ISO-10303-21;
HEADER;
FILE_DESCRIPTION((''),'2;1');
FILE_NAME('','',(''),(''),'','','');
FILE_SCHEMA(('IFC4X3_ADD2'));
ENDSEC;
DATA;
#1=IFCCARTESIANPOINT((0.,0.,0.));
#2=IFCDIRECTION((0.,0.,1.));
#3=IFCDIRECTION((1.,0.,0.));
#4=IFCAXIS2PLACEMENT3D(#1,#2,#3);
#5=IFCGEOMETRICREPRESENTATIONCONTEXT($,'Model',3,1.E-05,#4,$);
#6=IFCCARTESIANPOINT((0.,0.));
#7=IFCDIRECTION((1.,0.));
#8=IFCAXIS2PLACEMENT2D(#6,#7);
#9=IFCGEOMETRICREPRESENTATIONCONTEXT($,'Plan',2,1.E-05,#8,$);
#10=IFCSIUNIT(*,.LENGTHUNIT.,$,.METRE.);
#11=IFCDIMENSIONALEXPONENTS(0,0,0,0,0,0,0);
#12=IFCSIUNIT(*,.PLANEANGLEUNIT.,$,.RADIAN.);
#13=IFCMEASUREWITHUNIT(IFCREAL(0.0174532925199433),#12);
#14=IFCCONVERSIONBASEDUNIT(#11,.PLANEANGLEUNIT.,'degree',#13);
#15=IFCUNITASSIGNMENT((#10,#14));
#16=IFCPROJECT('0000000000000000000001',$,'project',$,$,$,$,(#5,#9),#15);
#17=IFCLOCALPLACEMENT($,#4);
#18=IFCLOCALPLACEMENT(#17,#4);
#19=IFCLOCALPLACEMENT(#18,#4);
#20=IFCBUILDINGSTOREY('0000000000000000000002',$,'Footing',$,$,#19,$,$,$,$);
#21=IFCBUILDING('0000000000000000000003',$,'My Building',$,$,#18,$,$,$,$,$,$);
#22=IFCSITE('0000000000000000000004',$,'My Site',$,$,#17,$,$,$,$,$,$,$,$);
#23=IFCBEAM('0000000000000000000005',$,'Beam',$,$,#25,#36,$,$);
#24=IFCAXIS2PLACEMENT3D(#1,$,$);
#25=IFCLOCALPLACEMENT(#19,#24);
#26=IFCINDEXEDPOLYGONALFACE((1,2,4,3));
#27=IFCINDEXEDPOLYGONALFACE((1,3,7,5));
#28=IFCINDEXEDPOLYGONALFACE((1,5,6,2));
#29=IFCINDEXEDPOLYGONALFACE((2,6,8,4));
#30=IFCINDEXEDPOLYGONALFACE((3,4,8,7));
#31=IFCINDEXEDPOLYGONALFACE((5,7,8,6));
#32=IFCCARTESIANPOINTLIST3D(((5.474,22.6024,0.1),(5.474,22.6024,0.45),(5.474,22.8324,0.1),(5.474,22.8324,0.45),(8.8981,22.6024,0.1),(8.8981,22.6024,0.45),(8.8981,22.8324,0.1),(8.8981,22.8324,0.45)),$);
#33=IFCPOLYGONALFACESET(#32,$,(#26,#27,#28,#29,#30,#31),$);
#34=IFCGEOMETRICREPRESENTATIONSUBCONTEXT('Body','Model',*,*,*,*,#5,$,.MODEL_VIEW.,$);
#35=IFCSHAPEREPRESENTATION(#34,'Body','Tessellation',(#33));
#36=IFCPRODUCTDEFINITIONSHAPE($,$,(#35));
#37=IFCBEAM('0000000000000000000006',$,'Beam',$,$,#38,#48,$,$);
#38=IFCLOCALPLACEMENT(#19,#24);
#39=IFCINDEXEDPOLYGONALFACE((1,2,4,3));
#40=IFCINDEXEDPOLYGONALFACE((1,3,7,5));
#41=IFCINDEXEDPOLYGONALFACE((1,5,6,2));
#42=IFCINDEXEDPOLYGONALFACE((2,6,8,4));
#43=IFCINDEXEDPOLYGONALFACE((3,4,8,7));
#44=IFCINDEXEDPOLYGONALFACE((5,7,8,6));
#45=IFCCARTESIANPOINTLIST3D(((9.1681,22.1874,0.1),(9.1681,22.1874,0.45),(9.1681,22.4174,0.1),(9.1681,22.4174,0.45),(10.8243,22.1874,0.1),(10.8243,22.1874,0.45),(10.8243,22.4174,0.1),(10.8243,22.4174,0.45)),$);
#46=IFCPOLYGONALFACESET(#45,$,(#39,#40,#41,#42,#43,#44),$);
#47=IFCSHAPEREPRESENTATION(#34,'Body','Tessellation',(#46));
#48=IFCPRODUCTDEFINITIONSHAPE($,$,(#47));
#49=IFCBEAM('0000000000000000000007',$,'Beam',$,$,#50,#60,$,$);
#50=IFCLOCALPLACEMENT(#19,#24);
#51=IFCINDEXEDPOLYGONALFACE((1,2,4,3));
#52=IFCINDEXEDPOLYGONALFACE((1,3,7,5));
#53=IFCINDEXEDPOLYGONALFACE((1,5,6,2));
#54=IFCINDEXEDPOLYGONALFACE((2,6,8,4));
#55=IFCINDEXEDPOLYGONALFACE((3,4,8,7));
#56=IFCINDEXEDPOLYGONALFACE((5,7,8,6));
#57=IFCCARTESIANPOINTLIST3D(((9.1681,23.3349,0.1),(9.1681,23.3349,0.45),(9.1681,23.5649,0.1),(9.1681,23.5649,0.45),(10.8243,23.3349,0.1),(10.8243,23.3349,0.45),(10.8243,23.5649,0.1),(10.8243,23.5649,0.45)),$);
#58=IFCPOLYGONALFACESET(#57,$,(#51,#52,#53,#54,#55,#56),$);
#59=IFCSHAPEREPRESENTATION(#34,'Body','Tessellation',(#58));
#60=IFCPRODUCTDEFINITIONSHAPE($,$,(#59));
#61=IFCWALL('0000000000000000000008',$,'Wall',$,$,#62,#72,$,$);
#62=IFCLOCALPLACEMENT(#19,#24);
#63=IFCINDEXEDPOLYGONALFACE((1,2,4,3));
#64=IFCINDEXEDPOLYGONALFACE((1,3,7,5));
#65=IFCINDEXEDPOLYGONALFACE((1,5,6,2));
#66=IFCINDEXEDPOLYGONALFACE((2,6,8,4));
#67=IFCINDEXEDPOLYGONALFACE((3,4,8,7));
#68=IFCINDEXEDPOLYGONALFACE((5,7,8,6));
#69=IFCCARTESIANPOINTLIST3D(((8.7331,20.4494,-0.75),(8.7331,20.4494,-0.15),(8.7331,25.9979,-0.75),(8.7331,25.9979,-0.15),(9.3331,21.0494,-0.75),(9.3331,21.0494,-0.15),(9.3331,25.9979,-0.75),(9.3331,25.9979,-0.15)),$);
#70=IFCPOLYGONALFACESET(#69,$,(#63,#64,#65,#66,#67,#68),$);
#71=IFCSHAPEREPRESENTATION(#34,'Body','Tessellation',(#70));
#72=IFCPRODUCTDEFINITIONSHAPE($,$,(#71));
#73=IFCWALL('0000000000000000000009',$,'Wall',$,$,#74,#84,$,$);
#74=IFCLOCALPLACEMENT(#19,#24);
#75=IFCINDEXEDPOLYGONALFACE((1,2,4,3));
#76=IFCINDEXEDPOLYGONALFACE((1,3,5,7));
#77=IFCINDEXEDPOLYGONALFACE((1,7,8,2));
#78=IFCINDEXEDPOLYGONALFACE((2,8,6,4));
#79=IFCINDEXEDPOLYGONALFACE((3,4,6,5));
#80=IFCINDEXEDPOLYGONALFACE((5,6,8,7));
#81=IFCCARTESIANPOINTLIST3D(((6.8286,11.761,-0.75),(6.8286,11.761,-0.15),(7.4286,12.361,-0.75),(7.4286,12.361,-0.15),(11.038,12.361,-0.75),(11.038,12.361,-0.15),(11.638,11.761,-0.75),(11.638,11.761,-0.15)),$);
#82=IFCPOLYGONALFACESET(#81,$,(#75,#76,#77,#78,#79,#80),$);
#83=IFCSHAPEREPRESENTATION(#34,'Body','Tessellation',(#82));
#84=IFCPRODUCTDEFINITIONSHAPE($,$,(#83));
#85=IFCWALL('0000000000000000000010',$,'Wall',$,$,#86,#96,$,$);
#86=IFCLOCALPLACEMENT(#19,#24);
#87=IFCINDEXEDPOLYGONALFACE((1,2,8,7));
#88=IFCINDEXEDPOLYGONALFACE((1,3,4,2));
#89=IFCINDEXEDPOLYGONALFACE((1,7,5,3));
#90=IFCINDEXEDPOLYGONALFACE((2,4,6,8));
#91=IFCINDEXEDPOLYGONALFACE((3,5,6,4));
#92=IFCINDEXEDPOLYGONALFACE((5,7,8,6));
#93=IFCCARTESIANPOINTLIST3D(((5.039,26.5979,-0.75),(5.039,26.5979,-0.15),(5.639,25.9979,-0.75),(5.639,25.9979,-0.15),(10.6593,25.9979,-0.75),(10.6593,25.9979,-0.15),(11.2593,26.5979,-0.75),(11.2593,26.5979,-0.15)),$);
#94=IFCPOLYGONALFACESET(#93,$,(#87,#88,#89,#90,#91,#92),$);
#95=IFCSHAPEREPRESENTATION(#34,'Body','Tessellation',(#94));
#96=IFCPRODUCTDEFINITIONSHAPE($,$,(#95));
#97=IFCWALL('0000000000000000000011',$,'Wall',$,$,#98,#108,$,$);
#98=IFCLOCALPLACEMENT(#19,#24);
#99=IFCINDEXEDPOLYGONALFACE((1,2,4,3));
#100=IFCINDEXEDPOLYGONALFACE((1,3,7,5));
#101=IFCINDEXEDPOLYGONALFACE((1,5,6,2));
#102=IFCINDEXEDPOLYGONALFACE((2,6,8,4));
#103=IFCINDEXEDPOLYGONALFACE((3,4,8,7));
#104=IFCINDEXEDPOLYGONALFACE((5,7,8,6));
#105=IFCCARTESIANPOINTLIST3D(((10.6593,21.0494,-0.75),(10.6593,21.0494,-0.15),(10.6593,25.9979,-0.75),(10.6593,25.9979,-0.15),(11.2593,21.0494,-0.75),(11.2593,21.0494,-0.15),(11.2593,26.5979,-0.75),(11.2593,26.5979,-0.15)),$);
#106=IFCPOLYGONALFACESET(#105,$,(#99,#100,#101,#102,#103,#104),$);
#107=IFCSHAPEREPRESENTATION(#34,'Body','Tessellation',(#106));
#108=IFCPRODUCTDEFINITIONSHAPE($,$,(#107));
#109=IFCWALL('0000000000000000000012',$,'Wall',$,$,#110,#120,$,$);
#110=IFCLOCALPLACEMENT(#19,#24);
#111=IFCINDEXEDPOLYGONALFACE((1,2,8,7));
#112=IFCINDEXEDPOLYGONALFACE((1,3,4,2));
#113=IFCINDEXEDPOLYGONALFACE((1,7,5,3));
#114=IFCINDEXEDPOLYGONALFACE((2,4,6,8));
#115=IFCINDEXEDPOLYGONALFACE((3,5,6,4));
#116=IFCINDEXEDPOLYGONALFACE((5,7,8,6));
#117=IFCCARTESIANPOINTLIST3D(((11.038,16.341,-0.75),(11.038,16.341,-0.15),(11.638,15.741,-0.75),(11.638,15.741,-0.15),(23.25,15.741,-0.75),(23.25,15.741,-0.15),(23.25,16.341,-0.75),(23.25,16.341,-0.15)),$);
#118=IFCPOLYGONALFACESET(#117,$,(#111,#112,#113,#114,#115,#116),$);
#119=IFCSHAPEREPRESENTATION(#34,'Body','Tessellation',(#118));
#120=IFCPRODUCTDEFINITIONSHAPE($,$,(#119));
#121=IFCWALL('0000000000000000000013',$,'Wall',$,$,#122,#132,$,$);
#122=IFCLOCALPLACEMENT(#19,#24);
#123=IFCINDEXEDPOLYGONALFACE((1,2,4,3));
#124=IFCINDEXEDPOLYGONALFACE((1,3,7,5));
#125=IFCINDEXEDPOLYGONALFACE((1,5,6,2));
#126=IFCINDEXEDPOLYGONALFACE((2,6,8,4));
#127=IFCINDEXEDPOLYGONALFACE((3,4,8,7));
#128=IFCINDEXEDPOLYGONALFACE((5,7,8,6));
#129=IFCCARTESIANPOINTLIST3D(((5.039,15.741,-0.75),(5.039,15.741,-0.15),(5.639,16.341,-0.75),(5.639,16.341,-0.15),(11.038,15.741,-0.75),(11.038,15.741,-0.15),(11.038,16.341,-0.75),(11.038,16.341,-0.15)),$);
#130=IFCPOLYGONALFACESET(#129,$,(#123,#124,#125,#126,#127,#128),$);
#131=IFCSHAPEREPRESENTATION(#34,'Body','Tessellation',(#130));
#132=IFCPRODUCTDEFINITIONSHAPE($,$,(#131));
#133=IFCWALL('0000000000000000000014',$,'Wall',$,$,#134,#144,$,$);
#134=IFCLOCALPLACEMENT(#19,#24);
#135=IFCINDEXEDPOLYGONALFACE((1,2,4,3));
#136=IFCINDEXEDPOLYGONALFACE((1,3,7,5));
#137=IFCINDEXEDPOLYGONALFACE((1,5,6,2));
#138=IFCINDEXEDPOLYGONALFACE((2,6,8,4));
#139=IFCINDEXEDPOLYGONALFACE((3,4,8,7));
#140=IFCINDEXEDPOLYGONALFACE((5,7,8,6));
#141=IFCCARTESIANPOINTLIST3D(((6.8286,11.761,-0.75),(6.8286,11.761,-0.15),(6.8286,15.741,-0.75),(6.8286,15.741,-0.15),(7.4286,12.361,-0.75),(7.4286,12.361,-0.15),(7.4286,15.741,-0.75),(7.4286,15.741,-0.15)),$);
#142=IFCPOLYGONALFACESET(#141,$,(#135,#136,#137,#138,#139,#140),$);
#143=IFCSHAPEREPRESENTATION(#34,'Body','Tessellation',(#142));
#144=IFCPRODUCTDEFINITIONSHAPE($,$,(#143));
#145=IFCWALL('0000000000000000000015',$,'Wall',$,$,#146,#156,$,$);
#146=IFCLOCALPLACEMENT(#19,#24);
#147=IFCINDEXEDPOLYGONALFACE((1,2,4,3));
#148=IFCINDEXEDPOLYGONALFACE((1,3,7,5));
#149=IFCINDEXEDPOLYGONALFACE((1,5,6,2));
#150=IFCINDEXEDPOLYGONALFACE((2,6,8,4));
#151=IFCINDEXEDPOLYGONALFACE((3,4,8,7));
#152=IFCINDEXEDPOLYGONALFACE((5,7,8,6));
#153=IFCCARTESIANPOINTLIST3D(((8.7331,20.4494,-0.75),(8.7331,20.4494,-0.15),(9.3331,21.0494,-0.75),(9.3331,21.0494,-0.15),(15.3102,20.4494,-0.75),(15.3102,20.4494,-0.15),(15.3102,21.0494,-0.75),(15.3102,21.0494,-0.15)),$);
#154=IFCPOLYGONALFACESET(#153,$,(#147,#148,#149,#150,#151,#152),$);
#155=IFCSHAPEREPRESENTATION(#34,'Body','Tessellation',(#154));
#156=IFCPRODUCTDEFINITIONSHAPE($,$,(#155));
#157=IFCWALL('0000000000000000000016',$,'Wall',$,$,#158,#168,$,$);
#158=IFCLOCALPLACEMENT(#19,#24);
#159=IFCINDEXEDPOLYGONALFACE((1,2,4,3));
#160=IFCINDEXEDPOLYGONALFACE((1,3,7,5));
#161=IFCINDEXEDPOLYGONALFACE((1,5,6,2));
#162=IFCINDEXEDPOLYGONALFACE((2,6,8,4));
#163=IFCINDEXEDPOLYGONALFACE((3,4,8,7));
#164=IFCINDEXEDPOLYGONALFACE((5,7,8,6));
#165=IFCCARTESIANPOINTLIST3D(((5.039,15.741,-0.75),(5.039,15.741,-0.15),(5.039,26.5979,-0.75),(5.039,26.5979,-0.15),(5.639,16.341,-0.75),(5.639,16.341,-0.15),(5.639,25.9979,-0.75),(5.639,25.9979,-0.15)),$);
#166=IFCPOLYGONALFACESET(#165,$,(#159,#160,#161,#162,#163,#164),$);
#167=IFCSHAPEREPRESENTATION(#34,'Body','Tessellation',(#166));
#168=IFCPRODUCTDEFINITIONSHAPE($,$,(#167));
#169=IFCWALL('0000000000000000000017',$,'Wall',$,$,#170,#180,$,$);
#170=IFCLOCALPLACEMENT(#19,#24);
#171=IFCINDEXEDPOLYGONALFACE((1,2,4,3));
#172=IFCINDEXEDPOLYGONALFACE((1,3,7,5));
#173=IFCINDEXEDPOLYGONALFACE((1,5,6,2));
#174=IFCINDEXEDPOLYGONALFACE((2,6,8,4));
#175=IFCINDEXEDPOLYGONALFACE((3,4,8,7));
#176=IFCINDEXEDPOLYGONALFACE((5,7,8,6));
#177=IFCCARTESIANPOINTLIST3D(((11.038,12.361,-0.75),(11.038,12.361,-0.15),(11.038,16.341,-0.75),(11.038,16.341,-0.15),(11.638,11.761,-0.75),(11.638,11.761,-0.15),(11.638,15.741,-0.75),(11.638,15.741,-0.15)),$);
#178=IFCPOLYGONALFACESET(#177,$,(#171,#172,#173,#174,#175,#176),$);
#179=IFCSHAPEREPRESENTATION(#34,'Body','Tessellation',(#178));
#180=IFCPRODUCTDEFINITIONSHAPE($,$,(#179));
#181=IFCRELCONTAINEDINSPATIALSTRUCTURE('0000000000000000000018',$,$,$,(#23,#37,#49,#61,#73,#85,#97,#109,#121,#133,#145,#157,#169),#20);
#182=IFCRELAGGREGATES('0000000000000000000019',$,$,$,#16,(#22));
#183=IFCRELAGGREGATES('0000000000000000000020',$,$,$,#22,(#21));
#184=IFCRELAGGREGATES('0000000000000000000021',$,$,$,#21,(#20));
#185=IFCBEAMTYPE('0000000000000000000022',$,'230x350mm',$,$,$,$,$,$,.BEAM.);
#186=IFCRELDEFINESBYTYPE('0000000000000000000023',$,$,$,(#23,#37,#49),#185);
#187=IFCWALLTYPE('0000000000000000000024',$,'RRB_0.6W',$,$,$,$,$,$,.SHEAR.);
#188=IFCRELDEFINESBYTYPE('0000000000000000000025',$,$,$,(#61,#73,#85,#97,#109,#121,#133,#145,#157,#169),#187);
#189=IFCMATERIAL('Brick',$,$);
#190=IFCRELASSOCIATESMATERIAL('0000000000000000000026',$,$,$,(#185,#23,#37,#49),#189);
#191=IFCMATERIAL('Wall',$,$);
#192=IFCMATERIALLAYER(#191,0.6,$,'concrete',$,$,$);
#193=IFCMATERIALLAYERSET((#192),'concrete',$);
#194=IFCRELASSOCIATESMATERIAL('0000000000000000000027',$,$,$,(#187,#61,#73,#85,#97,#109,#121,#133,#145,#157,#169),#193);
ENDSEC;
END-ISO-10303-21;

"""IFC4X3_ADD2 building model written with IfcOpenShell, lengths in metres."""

from ifc_helpers import new_model, entity, si_unit, converted_unit, frame, origin_with_axes, origin_2d_with_axis, place, context, subcontext, project, spatial, line, indexed_curve, rectangle, outline, extrude, material, layer, layer_set, layer_usage, material_profile, profile_set, profile_usage, type_object, element, save


model = new_model("IFC4X3_ADD2")

# Units and contexts
model_context = context("Model", 3, precision=1e-05, world=origin_with_axes())
plan_context = context("Plan", 2, precision=1e-05, world=origin_2d_with_axis())
body_context = subcontext(model_context, "Body", "Model", "MODEL_VIEW")
ifc_project = project(units=[si_unit("LENGTHUNIT", "METRE"), converted_unit("PLANEANGLEUNIT", "degree", entity("IfcReal", 0.0174532925199433), si_unit("PLANEANGLEUNIT", "RADIAN"), dimensions=[0, 0, 0, 0, 0, 0, 0])], contexts=[model_context, plan_context])

# Site, building, storey
site_placement = place(None, origin_with_axes())
site = spatial("IfcSite", under=ifc_project, at=site_placement, Name="My Site")
building_placement = place(site_placement, origin_with_axes())
building = spatial("IfcBuilding", under=site, at=building_placement, Name="My Building")
storey_placement = place(building_placement, origin_with_axes())
storey = spatial("IfcBuildingStorey", under=building, at=storey_placement, Name="Footing")

# Beams
ifc_material_1 = material(Name="Brick")
ifc_material_profile = material_profile(ifc_material_1, rectangle(XDim=0.23, YDim=0.35))
ifc_profile_set = profile_set([ifc_material_profile], Name="stone")
ifc_profile_usage_1 = profile_usage(ifc_profile_set)
beam_type = type_object("IfcBeamType", Name="230x350mm", PredefinedType="BEAM", material=ifc_profile_set)
beam_1_placement = place(storey_placement, frame((8.8981, 22.7174, 0.275), z_axis=(-1.0, 0.0, 0.0), x_axis=(0.0, -1.0, 0.0)))
element("IfcBeam", 1, at=beam_1_placement, inside=storey, type_object=beam_type, material=ifc_profile_usage_1, Name="Beam", context=body_context, shape_type="SweptSolid", body=[
    extrude(rectangle(XDim=0.23, YDim=0.35), origin_with_axes(), (0.0, 0.0, 1.0), 3.4241),
])
ifc_profile_usage_2 = profile_usage(ifc_profile_set)
beam_2_placement = place(storey_placement, frame((10.8243, 22.3024, 0.275), z_axis=(-1.0, 0.0, 0.0), x_axis=(0.0, -1.0, 0.0)))
element("IfcBeam", 2, at=beam_2_placement, inside=storey, type_object=beam_type, material=ifc_profile_usage_2, Name="Beam", context=body_context, shape_type="SweptSolid", body=[
    extrude(rectangle(XDim=0.23, YDim=0.35), origin_with_axes(), (0.0, 0.0, 1.0), 1.6562),
])
ifc_profile_usage_3 = profile_usage(ifc_profile_set)
beam_3_placement = place(storey_placement, frame((10.8243, 23.4499, 0.275), z_axis=(-1.0, 0.0, 0.0), x_axis=(0.0, -1.0, 0.0)))
element("IfcBeam", 3, at=beam_3_placement, inside=storey, type_object=beam_type, material=ifc_profile_usage_3, Name="Beam", context=body_context, shape_type="SweptSolid", body=[
    extrude(rectangle(XDim=0.23, YDim=0.35), origin_with_axes(), (0.0, 0.0, 1.0), 1.6562),
])

# Walls
ifc_material_2 = material(Name="Wall")
ifc_layer_1 = layer(ifc_material_2, 0.6, Name="concrete")
ifc_layer_set_1 = layer_set([ifc_layer_1], Name="concrete")
ifc_layer_usage_1 = layer_usage(ifc_layer_set_1, "AXIS2", "POSITIVE", 0.0)
wall_type_1 = type_object("IfcWallType", Name="RRB_0.6W", PredefinedType="SHEAR", material=ifc_layer_set_1)
wall_1_placement = place(storey_placement, frame((9.3331, 20.4494, -0.75), z_axis=(0.0, 0.0, 1.0), x_axis=(0.0, 1.0, 0.0)))
element("IfcWall", 4, at=wall_1_placement, inside=storey, type_object=wall_type_1, material=ifc_layer_usage_1, Name="Wall", context=body_context, shape_type="SweptSolid", body=[
    extrude(outline(indexed_curve([(0.6, 0.0), (0.0, 0.6), (5.5485, 0.6), (5.5485, 0.0)], segments=[line(1, 2, 3, 4, 1)])), origin_with_axes(), (0.0, 0.0, 1.0), 0.6),
])
ifc_layer_usage_2 = layer_usage(ifc_layer_set_1, "AXIS2", "POSITIVE", 0.0)
wall_2_placement = place(storey_placement, frame((11.638, 12.361, -0.75), z_axis=(0.0, 0.0, 1.0), x_axis=(-1.0, 0.0, 0.0)))
element("IfcWall", 5, at=wall_2_placement, inside=storey, type_object=wall_type_1, material=ifc_layer_usage_2, Name="Wall", context=body_context, shape_type="SweptSolid", body=[
    extrude(outline(indexed_curve([(0.6, 0.0), (0.0, 0.6), (4.8094, 0.6), (4.2094, 0.0)], segments=[line(1, 2, 3, 4, 1)])), origin_with_axes(), (0.0, 0.0, 1.0), 0.6),
])
ifc_layer_usage_3 = layer_usage(ifc_layer_set_1, "AXIS2", "POSITIVE", 0.0)
wall_3_placement = place(storey_placement, frame((11.2593, 26.5979, -0.75), z_axis=(0.0, 0.0, 1.0), x_axis=(-1.0, 0.0, 0.0)))
element("IfcWall", 6, at=wall_3_placement, inside=storey, type_object=wall_type_1, material=ifc_layer_usage_3, Name="Wall", context=body_context, shape_type="SweptSolid", body=[
    extrude(outline(indexed_curve([(0.0, 0.0), (0.6, 0.6), (5.6203, 0.6), (6.2203, 0.0)], segments=[line(1, 2, 3, 4, 1)])), origin_with_axes(), (0.0, 0.0, 1.0), 0.6),
])
ifc_layer_usage_4 = layer_usage(ifc_layer_set_1, "AXIS2", "POSITIVE", 0.0)
wall_4_placement = place(storey_placement, frame((11.2593, 20.4494, -0.75), z_axis=(0.0, 0.0, 1.0), x_axis=(0.0, 1.0, 0.0)))
element("IfcWall", 7, at=wall_4_placement, inside=storey, type_object=wall_type_1, material=ifc_layer_usage_4, Name="Wall", context=body_context, shape_type="SweptSolid", body=[
    extrude(outline(indexed_curve([(0.6, 0.0), (0.6, 0.6), (5.5485, 0.6), (6.1485, 0.0)], segments=[line(1, 2, 3, 4, 1)])), origin_with_axes(), (0.0, 0.0, 1.0), 0.6),
])
ifc_layer_usage_5 = layer_usage(ifc_layer_set_1, "AXIS2", "POSITIVE", 0.0)
wall_5_placement = place(storey_placement, frame((11.638, 15.741, -0.75), z_axis=(0.0, 0.0, 1.0), x_axis=(1.0, -0.000001, 0.0)))
element("IfcWall", 8, at=wall_5_placement, inside=storey, type_object=wall_type_1, material=ifc_layer_usage_5, Name="Wall", context=body_context, shape_type="SweptSolid", body=[
    extrude(outline(indexed_curve([(0.0, 0.0), (-0.6, 0.6), (11.612, 0.6), (11.612, 0.0)], segments=[line(1, 2, 3, 4, 1)])), origin_with_axes(), (0.0, 0.0, 1.0), 0.6),
])
ifc_layer_usage_6 = layer_usage(ifc_layer_set_1, "AXIS2", "POSITIVE", 0.0)
wall_6_placement = place(storey_placement, frame((11.638, 16.341, -0.75), z_axis=(0.0, 0.0, 1.0), x_axis=(-1.0, 0.0, 0.0)))
element("IfcWall", 9, at=wall_6_placement, inside=storey, type_object=wall_type_1, material=ifc_layer_usage_6, Name="Wall", context=body_context, shape_type="SweptSolid", body=[
    extrude(outline(indexed_curve([(0.6, 0.0), (0.6, 0.6), (6.599, 0.6), (5.999, 0.0)], segments=[line(1, 2, 3, 4, 1)])), origin_with_axes(), (0.0, 0.0, 1.0), 0.6),
])
ifc_layer_usage_7 = layer_usage(ifc_layer_set_1, "AXIS2", "POSITIVE", 0.0)
wall_7_placement = place(storey_placement, frame((7.4286, 12.361, -0.75), z_axis=(0.0, 0.0, 1.0), x_axis=(0.0, 1.0, 0.0)))
element("IfcWall", 10, at=wall_7_placement, inside=storey, type_object=wall_type_1, material=ifc_layer_usage_7, Name="Wall", context=body_context, shape_type="SweptSolid", body=[
    extrude(outline(indexed_curve([(0.0, 0.0), (-0.6, 0.6), (3.38, 0.6), (3.38, 0.0)], segments=[line(1, 2, 3, 4, 1)])), origin_with_axes(), (0.0, 0.0, 1.0), 0.6),
])
ifc_layer_usage_8 = layer_usage(ifc_layer_set_1, "AXIS2", "POSITIVE", 0.0)
wall_8_placement = place(storey_placement, frame((9.3331, 20.4494, -0.75), z_axis=(0.0, 0.0, 1.0), x_axis=(1.0, -0.000001, 0.0)))
element("IfcWall", 11, at=wall_8_placement, inside=storey, type_object=wall_type_1, material=ifc_layer_usage_8, Name="Wall", context=body_context, shape_type="SweptSolid", body=[
    extrude(outline(indexed_curve([(-0.6, 0.0), (0.0, 0.6), (5.9771, 0.6), (5.9771, 0.0)], segments=[line(1, 2, 3, 4, 1)])), origin_with_axes(), (0.0, 0.0, 1.0), 0.6),
])
ifc_layer_usage_9 = layer_usage(ifc_layer_set_1, "AXIS2", "POSITIVE", 0.0)
wall_9_placement = place(storey_placement, frame((5.639, 16.341, -0.75), z_axis=(0.0, 0.0, 1.0), x_axis=(0.0, 1.0, 0.0)))
element("IfcWall", 12, at=wall_9_placement, inside=storey, type_object=wall_type_1, material=ifc_layer_usage_9, Name="Wall", context=body_context, shape_type="SweptSolid", body=[
    extrude(outline(indexed_curve([(0.0, 0.0), (-0.6, 0.6), (10.2569, 0.6), (9.6569, 0.0)], segments=[line(1, 2, 3, 4, 1)])), origin_with_axes(), (0.0, 0.0, 1.0), 0.6),
])
ifc_layer_usage_10 = layer_usage(ifc_layer_set_1, "AXIS2", "POSITIVE", 0.0)
wall_10_placement = place(storey_placement, frame((11.638, 12.361, -0.75), z_axis=(0.0, 0.0, 1.0), x_axis=(0.0, 1.0, 0.0)))
element("IfcWall", 13, at=wall_10_placement, inside=storey, type_object=wall_type_1, material=ifc_layer_usage_10, Name="Wall", context=body_context, shape_type="SweptSolid", body=[
    extrude(outline(indexed_curve([(-0.6, 0.0), (0.0, 0.6), (3.98, 0.6), (3.38, 0.0)], segments=[line(1, 2, 3, 4, 1)])), origin_with_axes(), (0.0, 0.0, 1.0), 0.6),
])

save(model, "model.ifc")
